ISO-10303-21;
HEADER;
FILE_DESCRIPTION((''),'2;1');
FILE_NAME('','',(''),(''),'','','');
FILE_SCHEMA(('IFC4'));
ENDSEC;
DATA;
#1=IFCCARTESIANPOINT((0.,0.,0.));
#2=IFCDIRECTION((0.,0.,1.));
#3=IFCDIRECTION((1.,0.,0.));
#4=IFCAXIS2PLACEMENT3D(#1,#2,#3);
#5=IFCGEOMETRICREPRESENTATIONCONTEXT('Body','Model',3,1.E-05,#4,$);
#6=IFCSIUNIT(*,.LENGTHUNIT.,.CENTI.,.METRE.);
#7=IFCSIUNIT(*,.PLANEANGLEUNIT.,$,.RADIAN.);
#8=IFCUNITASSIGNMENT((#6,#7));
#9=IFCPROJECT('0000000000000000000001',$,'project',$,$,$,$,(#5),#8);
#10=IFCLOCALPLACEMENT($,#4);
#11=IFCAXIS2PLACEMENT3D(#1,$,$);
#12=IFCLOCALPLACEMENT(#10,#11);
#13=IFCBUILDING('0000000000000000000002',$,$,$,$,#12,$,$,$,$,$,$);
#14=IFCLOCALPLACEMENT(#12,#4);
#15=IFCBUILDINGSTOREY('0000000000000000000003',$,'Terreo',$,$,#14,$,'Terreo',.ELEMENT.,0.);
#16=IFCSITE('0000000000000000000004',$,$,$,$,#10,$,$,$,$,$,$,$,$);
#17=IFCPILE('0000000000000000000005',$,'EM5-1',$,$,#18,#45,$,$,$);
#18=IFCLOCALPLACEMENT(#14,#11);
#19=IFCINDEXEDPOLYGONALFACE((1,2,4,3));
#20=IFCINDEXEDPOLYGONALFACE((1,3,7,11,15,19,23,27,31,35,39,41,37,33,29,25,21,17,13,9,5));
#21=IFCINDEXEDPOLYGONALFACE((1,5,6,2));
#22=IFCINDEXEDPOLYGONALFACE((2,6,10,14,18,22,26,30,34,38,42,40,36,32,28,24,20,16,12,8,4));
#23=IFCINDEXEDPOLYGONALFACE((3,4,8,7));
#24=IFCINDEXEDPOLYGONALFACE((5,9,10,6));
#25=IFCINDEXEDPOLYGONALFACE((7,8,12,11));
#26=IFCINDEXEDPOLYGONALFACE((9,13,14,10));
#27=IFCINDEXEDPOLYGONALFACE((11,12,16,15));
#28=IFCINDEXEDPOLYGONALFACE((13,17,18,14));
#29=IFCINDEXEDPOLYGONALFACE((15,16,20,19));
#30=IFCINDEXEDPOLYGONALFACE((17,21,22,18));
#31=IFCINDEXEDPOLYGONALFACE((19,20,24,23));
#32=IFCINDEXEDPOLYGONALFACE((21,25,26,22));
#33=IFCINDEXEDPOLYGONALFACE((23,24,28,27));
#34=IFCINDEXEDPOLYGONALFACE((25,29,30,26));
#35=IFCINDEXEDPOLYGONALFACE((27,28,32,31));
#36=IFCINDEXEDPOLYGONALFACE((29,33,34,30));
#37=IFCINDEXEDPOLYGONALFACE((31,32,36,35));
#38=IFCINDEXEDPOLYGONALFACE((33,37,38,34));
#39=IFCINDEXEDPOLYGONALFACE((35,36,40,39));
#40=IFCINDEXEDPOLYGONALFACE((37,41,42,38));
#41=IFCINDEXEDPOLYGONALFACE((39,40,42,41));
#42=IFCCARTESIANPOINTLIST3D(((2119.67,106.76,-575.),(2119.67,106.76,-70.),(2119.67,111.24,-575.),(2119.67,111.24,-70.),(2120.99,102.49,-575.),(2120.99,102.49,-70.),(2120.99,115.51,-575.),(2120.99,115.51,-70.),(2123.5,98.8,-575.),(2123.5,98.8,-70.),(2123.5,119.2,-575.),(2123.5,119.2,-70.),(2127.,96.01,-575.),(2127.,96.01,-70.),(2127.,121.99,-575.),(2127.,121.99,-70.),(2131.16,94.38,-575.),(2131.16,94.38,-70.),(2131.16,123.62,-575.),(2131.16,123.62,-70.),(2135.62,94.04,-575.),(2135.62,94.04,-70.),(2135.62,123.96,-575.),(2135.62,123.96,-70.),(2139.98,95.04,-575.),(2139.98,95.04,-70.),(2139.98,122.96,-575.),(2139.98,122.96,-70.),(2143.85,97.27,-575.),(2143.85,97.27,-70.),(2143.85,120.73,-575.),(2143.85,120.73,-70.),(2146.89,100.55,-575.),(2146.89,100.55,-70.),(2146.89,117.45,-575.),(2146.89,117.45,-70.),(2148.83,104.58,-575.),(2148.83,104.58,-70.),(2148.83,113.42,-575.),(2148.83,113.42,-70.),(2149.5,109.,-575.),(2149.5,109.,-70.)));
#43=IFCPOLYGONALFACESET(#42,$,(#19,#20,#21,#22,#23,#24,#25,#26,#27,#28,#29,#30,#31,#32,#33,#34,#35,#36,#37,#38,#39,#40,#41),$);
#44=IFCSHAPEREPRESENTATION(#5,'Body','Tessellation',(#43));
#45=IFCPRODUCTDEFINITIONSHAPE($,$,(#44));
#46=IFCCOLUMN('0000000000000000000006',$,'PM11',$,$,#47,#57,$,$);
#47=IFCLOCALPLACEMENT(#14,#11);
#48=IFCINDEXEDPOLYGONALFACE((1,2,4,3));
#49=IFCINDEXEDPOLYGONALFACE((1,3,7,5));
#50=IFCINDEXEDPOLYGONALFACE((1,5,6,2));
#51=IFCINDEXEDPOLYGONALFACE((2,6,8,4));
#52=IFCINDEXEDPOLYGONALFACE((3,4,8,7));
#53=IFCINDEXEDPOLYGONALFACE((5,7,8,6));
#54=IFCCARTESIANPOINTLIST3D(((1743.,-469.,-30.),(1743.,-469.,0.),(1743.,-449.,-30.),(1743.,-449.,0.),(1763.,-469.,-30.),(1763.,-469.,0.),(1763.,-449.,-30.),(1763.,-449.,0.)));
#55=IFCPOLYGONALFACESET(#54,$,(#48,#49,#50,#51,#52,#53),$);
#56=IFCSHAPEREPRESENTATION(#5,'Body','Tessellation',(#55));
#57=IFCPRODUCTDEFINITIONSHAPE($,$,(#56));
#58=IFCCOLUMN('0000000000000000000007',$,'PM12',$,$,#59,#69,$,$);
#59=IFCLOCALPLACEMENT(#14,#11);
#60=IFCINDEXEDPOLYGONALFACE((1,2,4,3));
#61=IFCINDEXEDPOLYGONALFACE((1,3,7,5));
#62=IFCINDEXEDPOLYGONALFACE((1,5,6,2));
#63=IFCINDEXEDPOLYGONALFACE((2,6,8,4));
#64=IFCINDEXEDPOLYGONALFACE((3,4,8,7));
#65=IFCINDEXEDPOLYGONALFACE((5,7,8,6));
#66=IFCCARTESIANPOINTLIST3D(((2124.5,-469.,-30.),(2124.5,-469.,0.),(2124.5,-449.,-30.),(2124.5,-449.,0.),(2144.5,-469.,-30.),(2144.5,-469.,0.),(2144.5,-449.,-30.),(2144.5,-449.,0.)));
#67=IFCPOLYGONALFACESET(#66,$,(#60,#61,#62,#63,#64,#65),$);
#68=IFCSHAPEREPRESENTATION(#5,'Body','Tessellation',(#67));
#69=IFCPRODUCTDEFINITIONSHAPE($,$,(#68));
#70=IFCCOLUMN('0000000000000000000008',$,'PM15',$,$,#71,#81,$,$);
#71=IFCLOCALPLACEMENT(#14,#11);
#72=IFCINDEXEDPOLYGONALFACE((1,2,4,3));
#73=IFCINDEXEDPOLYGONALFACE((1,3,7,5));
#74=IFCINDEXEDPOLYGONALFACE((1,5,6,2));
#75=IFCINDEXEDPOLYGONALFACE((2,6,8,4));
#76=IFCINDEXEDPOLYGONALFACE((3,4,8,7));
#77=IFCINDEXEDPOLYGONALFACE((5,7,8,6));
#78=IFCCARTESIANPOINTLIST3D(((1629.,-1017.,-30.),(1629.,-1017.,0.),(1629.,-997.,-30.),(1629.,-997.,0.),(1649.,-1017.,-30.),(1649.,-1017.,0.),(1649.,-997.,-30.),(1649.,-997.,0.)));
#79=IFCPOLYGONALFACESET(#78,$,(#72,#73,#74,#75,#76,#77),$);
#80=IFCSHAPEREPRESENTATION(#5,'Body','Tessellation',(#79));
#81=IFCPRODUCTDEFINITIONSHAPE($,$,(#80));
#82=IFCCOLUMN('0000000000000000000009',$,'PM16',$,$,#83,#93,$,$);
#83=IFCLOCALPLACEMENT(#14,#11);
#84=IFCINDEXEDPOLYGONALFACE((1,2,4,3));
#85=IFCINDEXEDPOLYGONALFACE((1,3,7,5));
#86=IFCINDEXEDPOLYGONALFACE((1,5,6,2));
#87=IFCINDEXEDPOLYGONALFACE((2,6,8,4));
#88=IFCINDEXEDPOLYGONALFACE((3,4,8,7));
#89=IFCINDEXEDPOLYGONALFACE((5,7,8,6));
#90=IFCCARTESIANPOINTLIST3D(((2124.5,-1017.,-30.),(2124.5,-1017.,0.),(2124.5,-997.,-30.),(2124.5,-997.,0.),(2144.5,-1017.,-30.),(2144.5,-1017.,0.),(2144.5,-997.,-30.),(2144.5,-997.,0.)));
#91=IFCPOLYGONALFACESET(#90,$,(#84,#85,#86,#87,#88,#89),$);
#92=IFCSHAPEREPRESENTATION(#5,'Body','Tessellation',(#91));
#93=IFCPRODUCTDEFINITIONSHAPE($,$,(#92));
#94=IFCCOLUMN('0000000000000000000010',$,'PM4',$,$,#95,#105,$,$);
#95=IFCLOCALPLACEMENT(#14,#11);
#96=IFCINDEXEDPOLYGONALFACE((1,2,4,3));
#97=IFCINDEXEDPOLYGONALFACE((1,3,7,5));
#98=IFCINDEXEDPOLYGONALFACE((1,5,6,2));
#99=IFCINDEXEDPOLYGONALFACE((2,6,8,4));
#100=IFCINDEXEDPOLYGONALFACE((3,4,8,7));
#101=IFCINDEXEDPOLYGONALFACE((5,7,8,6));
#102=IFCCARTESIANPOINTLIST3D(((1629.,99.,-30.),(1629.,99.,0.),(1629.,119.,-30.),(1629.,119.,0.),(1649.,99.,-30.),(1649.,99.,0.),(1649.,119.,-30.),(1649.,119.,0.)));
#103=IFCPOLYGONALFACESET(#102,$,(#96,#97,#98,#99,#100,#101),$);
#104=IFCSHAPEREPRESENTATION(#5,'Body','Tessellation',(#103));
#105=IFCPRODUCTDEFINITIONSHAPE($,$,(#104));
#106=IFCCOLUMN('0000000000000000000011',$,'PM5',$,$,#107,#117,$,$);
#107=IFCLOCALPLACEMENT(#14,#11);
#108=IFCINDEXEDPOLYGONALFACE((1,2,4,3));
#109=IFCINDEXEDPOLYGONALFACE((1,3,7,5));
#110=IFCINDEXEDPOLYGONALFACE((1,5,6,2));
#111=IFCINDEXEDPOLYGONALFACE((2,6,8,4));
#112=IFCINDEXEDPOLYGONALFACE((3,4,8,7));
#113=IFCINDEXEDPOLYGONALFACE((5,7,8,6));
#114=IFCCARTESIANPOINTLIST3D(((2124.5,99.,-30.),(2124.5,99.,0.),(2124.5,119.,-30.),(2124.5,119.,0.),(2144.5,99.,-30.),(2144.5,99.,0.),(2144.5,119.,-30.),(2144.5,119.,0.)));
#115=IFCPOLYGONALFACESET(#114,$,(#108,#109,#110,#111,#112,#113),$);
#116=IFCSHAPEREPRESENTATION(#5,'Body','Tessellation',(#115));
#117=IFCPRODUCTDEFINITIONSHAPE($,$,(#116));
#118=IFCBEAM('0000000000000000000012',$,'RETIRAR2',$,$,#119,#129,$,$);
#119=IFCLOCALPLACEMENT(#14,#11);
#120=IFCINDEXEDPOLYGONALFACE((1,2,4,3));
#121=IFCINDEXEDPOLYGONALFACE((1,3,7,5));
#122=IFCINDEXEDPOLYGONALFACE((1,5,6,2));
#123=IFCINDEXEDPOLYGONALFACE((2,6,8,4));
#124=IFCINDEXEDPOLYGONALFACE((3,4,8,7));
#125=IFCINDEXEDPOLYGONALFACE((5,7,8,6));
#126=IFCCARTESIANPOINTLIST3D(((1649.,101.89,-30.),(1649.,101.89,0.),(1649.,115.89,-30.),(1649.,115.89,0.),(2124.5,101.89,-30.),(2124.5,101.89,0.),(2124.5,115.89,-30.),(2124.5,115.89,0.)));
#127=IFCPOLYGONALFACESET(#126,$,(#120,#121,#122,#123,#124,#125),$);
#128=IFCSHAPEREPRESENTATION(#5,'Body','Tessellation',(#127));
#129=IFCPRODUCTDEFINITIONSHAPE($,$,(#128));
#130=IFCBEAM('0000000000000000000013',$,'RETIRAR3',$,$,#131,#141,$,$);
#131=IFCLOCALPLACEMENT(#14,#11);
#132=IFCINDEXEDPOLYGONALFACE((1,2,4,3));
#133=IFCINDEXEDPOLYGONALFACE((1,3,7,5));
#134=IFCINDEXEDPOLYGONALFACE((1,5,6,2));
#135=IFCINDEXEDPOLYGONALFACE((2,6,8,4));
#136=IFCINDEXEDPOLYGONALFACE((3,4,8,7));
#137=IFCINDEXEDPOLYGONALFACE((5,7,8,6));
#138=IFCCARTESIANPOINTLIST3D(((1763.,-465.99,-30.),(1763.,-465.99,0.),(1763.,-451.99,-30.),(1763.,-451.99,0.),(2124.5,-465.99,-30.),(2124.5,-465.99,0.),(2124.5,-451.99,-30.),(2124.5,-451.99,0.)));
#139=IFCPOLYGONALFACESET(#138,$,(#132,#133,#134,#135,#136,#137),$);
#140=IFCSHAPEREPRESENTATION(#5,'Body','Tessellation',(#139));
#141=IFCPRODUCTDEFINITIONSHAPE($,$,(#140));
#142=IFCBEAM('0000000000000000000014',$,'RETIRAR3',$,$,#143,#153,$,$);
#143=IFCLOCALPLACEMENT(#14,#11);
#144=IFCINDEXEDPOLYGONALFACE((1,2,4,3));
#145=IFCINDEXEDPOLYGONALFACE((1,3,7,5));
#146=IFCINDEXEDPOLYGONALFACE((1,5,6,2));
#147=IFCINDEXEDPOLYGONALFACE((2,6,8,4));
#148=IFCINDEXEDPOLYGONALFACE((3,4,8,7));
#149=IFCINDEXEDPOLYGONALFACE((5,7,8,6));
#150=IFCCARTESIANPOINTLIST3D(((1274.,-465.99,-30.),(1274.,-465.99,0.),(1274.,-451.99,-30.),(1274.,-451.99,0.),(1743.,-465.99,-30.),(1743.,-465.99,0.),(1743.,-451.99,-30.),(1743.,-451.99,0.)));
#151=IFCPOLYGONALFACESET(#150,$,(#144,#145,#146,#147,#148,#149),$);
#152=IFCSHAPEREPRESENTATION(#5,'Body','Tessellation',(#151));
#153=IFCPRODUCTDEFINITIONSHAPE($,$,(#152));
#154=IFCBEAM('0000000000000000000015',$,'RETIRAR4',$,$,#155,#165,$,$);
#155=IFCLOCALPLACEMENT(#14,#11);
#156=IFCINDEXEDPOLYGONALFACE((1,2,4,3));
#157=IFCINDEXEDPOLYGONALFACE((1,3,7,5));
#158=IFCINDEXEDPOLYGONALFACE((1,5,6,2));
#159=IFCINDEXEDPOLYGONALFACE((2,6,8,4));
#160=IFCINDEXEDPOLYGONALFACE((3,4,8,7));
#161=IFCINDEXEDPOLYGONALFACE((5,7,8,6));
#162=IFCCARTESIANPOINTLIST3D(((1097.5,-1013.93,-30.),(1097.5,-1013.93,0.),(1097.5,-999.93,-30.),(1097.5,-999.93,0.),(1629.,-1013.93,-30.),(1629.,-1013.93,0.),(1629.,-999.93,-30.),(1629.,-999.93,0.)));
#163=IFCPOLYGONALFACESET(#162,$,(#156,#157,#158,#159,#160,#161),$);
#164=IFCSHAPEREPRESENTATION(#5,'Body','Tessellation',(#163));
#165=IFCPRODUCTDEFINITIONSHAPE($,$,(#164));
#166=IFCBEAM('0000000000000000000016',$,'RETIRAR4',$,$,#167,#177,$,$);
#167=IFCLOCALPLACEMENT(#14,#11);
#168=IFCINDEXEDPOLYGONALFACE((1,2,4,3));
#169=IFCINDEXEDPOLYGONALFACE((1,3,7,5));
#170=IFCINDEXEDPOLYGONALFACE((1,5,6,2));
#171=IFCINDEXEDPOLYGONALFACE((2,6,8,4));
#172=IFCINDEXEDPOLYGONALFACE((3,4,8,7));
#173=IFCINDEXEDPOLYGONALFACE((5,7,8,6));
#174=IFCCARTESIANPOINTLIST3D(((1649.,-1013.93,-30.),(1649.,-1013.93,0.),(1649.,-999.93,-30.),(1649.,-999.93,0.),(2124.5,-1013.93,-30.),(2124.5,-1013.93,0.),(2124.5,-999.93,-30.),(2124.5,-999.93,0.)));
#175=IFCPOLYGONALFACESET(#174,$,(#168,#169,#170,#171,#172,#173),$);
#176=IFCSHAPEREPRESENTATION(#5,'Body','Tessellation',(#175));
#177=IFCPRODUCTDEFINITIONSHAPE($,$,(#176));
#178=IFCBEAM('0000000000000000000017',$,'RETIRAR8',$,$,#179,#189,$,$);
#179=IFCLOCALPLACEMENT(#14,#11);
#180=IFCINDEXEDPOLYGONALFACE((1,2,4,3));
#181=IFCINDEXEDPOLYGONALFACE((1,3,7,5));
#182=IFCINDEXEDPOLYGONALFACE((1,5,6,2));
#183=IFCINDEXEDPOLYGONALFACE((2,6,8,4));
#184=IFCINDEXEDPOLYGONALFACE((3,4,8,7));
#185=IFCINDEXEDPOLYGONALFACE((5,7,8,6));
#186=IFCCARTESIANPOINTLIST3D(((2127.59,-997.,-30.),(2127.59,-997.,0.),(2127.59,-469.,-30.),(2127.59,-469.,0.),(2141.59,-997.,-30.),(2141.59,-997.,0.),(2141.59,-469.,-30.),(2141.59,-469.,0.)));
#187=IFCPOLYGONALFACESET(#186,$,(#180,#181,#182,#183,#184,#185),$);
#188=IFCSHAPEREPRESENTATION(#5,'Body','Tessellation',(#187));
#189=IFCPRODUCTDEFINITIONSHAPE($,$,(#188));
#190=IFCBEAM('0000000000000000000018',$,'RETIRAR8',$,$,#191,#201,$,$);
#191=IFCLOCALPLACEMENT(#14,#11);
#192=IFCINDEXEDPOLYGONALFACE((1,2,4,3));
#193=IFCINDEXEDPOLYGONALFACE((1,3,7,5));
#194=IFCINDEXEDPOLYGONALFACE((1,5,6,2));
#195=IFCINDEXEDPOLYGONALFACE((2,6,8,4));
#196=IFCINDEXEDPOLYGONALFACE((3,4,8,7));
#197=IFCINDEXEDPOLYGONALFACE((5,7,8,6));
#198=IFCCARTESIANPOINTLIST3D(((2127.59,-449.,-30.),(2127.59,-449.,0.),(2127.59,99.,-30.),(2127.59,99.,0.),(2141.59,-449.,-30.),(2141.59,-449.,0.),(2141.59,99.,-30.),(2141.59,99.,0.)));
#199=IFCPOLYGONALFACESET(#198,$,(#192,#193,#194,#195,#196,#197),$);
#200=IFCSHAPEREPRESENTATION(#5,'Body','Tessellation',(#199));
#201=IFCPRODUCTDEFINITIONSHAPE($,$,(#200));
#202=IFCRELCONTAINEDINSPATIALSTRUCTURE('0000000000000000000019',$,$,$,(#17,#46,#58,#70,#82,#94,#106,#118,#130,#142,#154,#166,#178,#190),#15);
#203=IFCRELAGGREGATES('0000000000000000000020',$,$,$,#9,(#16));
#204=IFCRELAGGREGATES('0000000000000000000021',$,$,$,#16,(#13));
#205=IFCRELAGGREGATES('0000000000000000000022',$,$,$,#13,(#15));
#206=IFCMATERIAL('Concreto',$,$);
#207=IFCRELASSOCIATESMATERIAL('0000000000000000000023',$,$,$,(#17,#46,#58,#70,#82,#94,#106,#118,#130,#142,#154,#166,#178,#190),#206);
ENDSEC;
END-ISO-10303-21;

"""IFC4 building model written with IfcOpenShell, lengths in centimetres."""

from ifc_helpers import new_model, si_unit, frame, origin, origin_with_axes, origin_2d_with_axis, place, context, project, spatial, rectangle, circle, extrude, material, element, save


model = new_model("IFC4")

# Units and contexts
model_context = context("Model", 3, precision=1e-05, world=origin_with_axes(), identifier="Body")
ifc_project = project(units=[si_unit("LENGTHUNIT", "METRE", prefix="CENTI"), si_unit("PLANEANGLEUNIT", "RADIAN")], contexts=[model_context])

# Site, building, storey
site_placement = place(None, origin_with_axes())
site = spatial("IfcSite", under=ifc_project, at=site_placement)
building_placement = place(site_placement, origin())
building = spatial("IfcBuilding", under=site, at=building_placement)
storey_placement = place(building_placement, origin_with_axes())
storey = spatial("IfcBuildingStorey", under=building, at=storey_placement, Name="Terreo", LongName="Terreo", CompositionType="ELEMENT", Elevation=0.0)

# Pile
ifc_material = material(Name="Concreto")
for number, where, z_axis, x_axis, name in (
    (1, (2134.5, 109.0, -70.0), (0.0, 0.0, 1.0), (1.0, 0.0, 0.0), "EM5-1"),
):
    element("IfcPile", number, at=place(storey_placement, frame(where, z_axis=z_axis, x_axis=x_axis)), inside=storey, material=ifc_material, Name=name, context=model_context, shape_type="SweptSolid", body=[
        extrude(circle(Radius=15.0, at=origin_2d_with_axis()), frame((0.0, 0.0, -505.0), z_axis=(0.0, 0.0, 1.0), x_axis=(1.0, 0.0, 0.0)), (0.0, 0.0, 1.0), 505.0),
    ])

# Columns
for number, where, z_axis, x_axis, name in (
    (2, (1753.0, -459.0, 0.0), (0.0, 0.0, 1.0), (1.0, 0.0, 0.0), "PM11"),
    (3, (2134.5, -459.0, 0.0), (0.0, 0.0, 1.0), (1.0, 0.0, 0.0), "PM12"),
    (4, (1639.0, -1007.0, 0.0), (0.0, 0.0, 1.0), (1.0, 0.0, 0.0), "PM15"),
    (5, (2134.5, -1007.0, 0.0), (0.0, 0.0, 1.0), (1.0, 0.0, 0.0), "PM16"),
    (6, (1639.0, 109.0, 0.0), (0.0, 0.0, 1.0), (1.0, 0.0, 0.0), "PM4"),
    (7, (2134.5, 109.0, 0.0), (0.0, 0.0, 1.0), (1.0, 0.0, 0.0), "PM5"),
):
    element("IfcColumn", number, at=place(storey_placement, frame(where, z_axis=z_axis, x_axis=x_axis)), inside=storey, material=ifc_material, Name=name, context=model_context, shape_type="SolidModel", body=[
        extrude(rectangle(XDim=20.0, YDim=20.0, at=origin_2d_with_axis()), frame((0.0, 0.0, -30.0), z_axis=(0.0, 0.0, 1.0), x_axis=(0.0, 1.0, 0.0)), (0.0, 0.0, 1.0), 30.0),
    ])

# Beams
beam_1_placement = place(storey_placement, frame((1886.75, 108.89, 0.0), z_axis=(0.0, 0.0, 1.0), x_axis=(1.0, 0.0, 0.0)))
element("IfcBeam", 8, at=beam_1_placement, inside=storey, material=ifc_material, Name="RETIRAR2", context=model_context, shape_type="SolidModel", body=[
    extrude(rectangle(XDim=14.0, YDim=30.0, at=origin_2d_with_axis()), frame((-237.75, 0.0, -15.0), z_axis=(1.0, 0.0, 0.0), x_axis=(0.0, 1.0, 0.0)), (0.0, 0.0, 1.0), 475.5),
])
beam_2_placement = place(storey_placement, frame((1943.75, -458.99, 0.0), z_axis=(0.0, 0.0, 1.0), x_axis=(1.0, 0.0, 0.0)))
element("IfcBeam", 9, at=beam_2_placement, inside=storey, material=ifc_material, Name="RETIRAR3", context=model_context, shape_type="SolidModel", body=[
    extrude(rectangle(XDim=14.0, YDim=30.0, at=origin_2d_with_axis()), frame((-180.75, 0.0, -15.0), z_axis=(1.0, 0.0, 0.0), x_axis=(0.0, 1.0, 0.0)), (0.0, 0.0, 1.0), 361.5),
])
beam_3_placement = place(storey_placement, frame((1508.5, -458.99, 0.0), z_axis=(0.0, 0.0, 1.0), x_axis=(1.0, 0.0, 0.0)))
element("IfcBeam", 10, at=beam_3_placement, inside=storey, material=ifc_material, Name="RETIRAR3", context=model_context, shape_type="SolidModel", body=[
    extrude(rectangle(XDim=14.0, YDim=30.0, at=origin_2d_with_axis()), frame((-234.5, 0.0, -15.0), z_axis=(1.0, 0.0, 0.0), x_axis=(0.0, 1.0, 0.0)), (0.0, 0.0, 1.0), 469.0),
])
beam_4_placement = place(storey_placement, frame((1363.25, -1006.93, 0.0), z_axis=(0.0, 0.0, 1.0), x_axis=(1.0, 0.0, 0.0)))
element("IfcBeam", 11, at=beam_4_placement, inside=storey, material=ifc_material, Name="RETIRAR4", context=model_context, shape_type="SolidModel", body=[
    extrude(rectangle(XDim=14.0, YDim=30.0, at=origin_2d_with_axis()), frame((-265.75, 0.0, -15.0), z_axis=(1.0, 0.0, 0.0), x_axis=(0.0, -1.0, 0.0)), (0.0, 0.0, 1.0), 531.5),
])
beam_5_placement = place(storey_placement, frame((1886.75, -1006.93, 0.0), z_axis=(0.0, 0.0, 1.0), x_axis=(1.0, 0.0, 0.0)))
element("IfcBeam", 12, at=beam_5_placement, inside=storey, material=ifc_material, Name="RETIRAR4", context=model_context, shape_type="SolidModel", body=[
    extrude(rectangle(XDim=14.0, YDim=30.0, at=origin_2d_with_axis()), frame((-237.75, 0.0, -15.0), z_axis=(1.0, 0.0, 0.0), x_axis=(0.0, 1.0, 0.0)), (0.0, 0.0, 1.0), 475.5),
])
beam_6_placement = place(storey_placement, frame((2134.59, -733.0, 0.0), z_axis=(0.0, 0.0, 1.0), x_axis=(1.0, 0.0, 0.0)))
element("IfcBeam", 13, at=beam_6_placement, inside=storey, material=ifc_material, Name="RETIRAR8", context=model_context, shape_type="SolidModel", body=[
    extrude(rectangle(XDim=14.0, YDim=30.0, at=origin_2d_with_axis()), frame((0.0, -264.0, -15.0), z_axis=(0.0, 1.0, 0.0), x_axis=(1.0, 0.0, 0.0)), (0.0, 0.0, 1.0), 528.0),
])
beam_7_placement = place(storey_placement, frame((2134.59, -175.0, 0.0), z_axis=(0.0, 0.0, 1.0), x_axis=(1.0, 0.0, 0.0)))
element("IfcBeam", 14, at=beam_7_placement, inside=storey, material=ifc_material, Name="RETIRAR8", context=model_context, shape_type="SolidModel", body=[
    extrude(rectangle(XDim=14.0, YDim=30.0, at=origin_2d_with_axis()), frame((0.0, -274.0, -15.0), z_axis=(0.0, 1.0, 0.0), x_axis=(1.0, 0.0, 0.0)), (0.0, 0.0, 1.0), 548.0),
])

save(model, "model.ifc")
